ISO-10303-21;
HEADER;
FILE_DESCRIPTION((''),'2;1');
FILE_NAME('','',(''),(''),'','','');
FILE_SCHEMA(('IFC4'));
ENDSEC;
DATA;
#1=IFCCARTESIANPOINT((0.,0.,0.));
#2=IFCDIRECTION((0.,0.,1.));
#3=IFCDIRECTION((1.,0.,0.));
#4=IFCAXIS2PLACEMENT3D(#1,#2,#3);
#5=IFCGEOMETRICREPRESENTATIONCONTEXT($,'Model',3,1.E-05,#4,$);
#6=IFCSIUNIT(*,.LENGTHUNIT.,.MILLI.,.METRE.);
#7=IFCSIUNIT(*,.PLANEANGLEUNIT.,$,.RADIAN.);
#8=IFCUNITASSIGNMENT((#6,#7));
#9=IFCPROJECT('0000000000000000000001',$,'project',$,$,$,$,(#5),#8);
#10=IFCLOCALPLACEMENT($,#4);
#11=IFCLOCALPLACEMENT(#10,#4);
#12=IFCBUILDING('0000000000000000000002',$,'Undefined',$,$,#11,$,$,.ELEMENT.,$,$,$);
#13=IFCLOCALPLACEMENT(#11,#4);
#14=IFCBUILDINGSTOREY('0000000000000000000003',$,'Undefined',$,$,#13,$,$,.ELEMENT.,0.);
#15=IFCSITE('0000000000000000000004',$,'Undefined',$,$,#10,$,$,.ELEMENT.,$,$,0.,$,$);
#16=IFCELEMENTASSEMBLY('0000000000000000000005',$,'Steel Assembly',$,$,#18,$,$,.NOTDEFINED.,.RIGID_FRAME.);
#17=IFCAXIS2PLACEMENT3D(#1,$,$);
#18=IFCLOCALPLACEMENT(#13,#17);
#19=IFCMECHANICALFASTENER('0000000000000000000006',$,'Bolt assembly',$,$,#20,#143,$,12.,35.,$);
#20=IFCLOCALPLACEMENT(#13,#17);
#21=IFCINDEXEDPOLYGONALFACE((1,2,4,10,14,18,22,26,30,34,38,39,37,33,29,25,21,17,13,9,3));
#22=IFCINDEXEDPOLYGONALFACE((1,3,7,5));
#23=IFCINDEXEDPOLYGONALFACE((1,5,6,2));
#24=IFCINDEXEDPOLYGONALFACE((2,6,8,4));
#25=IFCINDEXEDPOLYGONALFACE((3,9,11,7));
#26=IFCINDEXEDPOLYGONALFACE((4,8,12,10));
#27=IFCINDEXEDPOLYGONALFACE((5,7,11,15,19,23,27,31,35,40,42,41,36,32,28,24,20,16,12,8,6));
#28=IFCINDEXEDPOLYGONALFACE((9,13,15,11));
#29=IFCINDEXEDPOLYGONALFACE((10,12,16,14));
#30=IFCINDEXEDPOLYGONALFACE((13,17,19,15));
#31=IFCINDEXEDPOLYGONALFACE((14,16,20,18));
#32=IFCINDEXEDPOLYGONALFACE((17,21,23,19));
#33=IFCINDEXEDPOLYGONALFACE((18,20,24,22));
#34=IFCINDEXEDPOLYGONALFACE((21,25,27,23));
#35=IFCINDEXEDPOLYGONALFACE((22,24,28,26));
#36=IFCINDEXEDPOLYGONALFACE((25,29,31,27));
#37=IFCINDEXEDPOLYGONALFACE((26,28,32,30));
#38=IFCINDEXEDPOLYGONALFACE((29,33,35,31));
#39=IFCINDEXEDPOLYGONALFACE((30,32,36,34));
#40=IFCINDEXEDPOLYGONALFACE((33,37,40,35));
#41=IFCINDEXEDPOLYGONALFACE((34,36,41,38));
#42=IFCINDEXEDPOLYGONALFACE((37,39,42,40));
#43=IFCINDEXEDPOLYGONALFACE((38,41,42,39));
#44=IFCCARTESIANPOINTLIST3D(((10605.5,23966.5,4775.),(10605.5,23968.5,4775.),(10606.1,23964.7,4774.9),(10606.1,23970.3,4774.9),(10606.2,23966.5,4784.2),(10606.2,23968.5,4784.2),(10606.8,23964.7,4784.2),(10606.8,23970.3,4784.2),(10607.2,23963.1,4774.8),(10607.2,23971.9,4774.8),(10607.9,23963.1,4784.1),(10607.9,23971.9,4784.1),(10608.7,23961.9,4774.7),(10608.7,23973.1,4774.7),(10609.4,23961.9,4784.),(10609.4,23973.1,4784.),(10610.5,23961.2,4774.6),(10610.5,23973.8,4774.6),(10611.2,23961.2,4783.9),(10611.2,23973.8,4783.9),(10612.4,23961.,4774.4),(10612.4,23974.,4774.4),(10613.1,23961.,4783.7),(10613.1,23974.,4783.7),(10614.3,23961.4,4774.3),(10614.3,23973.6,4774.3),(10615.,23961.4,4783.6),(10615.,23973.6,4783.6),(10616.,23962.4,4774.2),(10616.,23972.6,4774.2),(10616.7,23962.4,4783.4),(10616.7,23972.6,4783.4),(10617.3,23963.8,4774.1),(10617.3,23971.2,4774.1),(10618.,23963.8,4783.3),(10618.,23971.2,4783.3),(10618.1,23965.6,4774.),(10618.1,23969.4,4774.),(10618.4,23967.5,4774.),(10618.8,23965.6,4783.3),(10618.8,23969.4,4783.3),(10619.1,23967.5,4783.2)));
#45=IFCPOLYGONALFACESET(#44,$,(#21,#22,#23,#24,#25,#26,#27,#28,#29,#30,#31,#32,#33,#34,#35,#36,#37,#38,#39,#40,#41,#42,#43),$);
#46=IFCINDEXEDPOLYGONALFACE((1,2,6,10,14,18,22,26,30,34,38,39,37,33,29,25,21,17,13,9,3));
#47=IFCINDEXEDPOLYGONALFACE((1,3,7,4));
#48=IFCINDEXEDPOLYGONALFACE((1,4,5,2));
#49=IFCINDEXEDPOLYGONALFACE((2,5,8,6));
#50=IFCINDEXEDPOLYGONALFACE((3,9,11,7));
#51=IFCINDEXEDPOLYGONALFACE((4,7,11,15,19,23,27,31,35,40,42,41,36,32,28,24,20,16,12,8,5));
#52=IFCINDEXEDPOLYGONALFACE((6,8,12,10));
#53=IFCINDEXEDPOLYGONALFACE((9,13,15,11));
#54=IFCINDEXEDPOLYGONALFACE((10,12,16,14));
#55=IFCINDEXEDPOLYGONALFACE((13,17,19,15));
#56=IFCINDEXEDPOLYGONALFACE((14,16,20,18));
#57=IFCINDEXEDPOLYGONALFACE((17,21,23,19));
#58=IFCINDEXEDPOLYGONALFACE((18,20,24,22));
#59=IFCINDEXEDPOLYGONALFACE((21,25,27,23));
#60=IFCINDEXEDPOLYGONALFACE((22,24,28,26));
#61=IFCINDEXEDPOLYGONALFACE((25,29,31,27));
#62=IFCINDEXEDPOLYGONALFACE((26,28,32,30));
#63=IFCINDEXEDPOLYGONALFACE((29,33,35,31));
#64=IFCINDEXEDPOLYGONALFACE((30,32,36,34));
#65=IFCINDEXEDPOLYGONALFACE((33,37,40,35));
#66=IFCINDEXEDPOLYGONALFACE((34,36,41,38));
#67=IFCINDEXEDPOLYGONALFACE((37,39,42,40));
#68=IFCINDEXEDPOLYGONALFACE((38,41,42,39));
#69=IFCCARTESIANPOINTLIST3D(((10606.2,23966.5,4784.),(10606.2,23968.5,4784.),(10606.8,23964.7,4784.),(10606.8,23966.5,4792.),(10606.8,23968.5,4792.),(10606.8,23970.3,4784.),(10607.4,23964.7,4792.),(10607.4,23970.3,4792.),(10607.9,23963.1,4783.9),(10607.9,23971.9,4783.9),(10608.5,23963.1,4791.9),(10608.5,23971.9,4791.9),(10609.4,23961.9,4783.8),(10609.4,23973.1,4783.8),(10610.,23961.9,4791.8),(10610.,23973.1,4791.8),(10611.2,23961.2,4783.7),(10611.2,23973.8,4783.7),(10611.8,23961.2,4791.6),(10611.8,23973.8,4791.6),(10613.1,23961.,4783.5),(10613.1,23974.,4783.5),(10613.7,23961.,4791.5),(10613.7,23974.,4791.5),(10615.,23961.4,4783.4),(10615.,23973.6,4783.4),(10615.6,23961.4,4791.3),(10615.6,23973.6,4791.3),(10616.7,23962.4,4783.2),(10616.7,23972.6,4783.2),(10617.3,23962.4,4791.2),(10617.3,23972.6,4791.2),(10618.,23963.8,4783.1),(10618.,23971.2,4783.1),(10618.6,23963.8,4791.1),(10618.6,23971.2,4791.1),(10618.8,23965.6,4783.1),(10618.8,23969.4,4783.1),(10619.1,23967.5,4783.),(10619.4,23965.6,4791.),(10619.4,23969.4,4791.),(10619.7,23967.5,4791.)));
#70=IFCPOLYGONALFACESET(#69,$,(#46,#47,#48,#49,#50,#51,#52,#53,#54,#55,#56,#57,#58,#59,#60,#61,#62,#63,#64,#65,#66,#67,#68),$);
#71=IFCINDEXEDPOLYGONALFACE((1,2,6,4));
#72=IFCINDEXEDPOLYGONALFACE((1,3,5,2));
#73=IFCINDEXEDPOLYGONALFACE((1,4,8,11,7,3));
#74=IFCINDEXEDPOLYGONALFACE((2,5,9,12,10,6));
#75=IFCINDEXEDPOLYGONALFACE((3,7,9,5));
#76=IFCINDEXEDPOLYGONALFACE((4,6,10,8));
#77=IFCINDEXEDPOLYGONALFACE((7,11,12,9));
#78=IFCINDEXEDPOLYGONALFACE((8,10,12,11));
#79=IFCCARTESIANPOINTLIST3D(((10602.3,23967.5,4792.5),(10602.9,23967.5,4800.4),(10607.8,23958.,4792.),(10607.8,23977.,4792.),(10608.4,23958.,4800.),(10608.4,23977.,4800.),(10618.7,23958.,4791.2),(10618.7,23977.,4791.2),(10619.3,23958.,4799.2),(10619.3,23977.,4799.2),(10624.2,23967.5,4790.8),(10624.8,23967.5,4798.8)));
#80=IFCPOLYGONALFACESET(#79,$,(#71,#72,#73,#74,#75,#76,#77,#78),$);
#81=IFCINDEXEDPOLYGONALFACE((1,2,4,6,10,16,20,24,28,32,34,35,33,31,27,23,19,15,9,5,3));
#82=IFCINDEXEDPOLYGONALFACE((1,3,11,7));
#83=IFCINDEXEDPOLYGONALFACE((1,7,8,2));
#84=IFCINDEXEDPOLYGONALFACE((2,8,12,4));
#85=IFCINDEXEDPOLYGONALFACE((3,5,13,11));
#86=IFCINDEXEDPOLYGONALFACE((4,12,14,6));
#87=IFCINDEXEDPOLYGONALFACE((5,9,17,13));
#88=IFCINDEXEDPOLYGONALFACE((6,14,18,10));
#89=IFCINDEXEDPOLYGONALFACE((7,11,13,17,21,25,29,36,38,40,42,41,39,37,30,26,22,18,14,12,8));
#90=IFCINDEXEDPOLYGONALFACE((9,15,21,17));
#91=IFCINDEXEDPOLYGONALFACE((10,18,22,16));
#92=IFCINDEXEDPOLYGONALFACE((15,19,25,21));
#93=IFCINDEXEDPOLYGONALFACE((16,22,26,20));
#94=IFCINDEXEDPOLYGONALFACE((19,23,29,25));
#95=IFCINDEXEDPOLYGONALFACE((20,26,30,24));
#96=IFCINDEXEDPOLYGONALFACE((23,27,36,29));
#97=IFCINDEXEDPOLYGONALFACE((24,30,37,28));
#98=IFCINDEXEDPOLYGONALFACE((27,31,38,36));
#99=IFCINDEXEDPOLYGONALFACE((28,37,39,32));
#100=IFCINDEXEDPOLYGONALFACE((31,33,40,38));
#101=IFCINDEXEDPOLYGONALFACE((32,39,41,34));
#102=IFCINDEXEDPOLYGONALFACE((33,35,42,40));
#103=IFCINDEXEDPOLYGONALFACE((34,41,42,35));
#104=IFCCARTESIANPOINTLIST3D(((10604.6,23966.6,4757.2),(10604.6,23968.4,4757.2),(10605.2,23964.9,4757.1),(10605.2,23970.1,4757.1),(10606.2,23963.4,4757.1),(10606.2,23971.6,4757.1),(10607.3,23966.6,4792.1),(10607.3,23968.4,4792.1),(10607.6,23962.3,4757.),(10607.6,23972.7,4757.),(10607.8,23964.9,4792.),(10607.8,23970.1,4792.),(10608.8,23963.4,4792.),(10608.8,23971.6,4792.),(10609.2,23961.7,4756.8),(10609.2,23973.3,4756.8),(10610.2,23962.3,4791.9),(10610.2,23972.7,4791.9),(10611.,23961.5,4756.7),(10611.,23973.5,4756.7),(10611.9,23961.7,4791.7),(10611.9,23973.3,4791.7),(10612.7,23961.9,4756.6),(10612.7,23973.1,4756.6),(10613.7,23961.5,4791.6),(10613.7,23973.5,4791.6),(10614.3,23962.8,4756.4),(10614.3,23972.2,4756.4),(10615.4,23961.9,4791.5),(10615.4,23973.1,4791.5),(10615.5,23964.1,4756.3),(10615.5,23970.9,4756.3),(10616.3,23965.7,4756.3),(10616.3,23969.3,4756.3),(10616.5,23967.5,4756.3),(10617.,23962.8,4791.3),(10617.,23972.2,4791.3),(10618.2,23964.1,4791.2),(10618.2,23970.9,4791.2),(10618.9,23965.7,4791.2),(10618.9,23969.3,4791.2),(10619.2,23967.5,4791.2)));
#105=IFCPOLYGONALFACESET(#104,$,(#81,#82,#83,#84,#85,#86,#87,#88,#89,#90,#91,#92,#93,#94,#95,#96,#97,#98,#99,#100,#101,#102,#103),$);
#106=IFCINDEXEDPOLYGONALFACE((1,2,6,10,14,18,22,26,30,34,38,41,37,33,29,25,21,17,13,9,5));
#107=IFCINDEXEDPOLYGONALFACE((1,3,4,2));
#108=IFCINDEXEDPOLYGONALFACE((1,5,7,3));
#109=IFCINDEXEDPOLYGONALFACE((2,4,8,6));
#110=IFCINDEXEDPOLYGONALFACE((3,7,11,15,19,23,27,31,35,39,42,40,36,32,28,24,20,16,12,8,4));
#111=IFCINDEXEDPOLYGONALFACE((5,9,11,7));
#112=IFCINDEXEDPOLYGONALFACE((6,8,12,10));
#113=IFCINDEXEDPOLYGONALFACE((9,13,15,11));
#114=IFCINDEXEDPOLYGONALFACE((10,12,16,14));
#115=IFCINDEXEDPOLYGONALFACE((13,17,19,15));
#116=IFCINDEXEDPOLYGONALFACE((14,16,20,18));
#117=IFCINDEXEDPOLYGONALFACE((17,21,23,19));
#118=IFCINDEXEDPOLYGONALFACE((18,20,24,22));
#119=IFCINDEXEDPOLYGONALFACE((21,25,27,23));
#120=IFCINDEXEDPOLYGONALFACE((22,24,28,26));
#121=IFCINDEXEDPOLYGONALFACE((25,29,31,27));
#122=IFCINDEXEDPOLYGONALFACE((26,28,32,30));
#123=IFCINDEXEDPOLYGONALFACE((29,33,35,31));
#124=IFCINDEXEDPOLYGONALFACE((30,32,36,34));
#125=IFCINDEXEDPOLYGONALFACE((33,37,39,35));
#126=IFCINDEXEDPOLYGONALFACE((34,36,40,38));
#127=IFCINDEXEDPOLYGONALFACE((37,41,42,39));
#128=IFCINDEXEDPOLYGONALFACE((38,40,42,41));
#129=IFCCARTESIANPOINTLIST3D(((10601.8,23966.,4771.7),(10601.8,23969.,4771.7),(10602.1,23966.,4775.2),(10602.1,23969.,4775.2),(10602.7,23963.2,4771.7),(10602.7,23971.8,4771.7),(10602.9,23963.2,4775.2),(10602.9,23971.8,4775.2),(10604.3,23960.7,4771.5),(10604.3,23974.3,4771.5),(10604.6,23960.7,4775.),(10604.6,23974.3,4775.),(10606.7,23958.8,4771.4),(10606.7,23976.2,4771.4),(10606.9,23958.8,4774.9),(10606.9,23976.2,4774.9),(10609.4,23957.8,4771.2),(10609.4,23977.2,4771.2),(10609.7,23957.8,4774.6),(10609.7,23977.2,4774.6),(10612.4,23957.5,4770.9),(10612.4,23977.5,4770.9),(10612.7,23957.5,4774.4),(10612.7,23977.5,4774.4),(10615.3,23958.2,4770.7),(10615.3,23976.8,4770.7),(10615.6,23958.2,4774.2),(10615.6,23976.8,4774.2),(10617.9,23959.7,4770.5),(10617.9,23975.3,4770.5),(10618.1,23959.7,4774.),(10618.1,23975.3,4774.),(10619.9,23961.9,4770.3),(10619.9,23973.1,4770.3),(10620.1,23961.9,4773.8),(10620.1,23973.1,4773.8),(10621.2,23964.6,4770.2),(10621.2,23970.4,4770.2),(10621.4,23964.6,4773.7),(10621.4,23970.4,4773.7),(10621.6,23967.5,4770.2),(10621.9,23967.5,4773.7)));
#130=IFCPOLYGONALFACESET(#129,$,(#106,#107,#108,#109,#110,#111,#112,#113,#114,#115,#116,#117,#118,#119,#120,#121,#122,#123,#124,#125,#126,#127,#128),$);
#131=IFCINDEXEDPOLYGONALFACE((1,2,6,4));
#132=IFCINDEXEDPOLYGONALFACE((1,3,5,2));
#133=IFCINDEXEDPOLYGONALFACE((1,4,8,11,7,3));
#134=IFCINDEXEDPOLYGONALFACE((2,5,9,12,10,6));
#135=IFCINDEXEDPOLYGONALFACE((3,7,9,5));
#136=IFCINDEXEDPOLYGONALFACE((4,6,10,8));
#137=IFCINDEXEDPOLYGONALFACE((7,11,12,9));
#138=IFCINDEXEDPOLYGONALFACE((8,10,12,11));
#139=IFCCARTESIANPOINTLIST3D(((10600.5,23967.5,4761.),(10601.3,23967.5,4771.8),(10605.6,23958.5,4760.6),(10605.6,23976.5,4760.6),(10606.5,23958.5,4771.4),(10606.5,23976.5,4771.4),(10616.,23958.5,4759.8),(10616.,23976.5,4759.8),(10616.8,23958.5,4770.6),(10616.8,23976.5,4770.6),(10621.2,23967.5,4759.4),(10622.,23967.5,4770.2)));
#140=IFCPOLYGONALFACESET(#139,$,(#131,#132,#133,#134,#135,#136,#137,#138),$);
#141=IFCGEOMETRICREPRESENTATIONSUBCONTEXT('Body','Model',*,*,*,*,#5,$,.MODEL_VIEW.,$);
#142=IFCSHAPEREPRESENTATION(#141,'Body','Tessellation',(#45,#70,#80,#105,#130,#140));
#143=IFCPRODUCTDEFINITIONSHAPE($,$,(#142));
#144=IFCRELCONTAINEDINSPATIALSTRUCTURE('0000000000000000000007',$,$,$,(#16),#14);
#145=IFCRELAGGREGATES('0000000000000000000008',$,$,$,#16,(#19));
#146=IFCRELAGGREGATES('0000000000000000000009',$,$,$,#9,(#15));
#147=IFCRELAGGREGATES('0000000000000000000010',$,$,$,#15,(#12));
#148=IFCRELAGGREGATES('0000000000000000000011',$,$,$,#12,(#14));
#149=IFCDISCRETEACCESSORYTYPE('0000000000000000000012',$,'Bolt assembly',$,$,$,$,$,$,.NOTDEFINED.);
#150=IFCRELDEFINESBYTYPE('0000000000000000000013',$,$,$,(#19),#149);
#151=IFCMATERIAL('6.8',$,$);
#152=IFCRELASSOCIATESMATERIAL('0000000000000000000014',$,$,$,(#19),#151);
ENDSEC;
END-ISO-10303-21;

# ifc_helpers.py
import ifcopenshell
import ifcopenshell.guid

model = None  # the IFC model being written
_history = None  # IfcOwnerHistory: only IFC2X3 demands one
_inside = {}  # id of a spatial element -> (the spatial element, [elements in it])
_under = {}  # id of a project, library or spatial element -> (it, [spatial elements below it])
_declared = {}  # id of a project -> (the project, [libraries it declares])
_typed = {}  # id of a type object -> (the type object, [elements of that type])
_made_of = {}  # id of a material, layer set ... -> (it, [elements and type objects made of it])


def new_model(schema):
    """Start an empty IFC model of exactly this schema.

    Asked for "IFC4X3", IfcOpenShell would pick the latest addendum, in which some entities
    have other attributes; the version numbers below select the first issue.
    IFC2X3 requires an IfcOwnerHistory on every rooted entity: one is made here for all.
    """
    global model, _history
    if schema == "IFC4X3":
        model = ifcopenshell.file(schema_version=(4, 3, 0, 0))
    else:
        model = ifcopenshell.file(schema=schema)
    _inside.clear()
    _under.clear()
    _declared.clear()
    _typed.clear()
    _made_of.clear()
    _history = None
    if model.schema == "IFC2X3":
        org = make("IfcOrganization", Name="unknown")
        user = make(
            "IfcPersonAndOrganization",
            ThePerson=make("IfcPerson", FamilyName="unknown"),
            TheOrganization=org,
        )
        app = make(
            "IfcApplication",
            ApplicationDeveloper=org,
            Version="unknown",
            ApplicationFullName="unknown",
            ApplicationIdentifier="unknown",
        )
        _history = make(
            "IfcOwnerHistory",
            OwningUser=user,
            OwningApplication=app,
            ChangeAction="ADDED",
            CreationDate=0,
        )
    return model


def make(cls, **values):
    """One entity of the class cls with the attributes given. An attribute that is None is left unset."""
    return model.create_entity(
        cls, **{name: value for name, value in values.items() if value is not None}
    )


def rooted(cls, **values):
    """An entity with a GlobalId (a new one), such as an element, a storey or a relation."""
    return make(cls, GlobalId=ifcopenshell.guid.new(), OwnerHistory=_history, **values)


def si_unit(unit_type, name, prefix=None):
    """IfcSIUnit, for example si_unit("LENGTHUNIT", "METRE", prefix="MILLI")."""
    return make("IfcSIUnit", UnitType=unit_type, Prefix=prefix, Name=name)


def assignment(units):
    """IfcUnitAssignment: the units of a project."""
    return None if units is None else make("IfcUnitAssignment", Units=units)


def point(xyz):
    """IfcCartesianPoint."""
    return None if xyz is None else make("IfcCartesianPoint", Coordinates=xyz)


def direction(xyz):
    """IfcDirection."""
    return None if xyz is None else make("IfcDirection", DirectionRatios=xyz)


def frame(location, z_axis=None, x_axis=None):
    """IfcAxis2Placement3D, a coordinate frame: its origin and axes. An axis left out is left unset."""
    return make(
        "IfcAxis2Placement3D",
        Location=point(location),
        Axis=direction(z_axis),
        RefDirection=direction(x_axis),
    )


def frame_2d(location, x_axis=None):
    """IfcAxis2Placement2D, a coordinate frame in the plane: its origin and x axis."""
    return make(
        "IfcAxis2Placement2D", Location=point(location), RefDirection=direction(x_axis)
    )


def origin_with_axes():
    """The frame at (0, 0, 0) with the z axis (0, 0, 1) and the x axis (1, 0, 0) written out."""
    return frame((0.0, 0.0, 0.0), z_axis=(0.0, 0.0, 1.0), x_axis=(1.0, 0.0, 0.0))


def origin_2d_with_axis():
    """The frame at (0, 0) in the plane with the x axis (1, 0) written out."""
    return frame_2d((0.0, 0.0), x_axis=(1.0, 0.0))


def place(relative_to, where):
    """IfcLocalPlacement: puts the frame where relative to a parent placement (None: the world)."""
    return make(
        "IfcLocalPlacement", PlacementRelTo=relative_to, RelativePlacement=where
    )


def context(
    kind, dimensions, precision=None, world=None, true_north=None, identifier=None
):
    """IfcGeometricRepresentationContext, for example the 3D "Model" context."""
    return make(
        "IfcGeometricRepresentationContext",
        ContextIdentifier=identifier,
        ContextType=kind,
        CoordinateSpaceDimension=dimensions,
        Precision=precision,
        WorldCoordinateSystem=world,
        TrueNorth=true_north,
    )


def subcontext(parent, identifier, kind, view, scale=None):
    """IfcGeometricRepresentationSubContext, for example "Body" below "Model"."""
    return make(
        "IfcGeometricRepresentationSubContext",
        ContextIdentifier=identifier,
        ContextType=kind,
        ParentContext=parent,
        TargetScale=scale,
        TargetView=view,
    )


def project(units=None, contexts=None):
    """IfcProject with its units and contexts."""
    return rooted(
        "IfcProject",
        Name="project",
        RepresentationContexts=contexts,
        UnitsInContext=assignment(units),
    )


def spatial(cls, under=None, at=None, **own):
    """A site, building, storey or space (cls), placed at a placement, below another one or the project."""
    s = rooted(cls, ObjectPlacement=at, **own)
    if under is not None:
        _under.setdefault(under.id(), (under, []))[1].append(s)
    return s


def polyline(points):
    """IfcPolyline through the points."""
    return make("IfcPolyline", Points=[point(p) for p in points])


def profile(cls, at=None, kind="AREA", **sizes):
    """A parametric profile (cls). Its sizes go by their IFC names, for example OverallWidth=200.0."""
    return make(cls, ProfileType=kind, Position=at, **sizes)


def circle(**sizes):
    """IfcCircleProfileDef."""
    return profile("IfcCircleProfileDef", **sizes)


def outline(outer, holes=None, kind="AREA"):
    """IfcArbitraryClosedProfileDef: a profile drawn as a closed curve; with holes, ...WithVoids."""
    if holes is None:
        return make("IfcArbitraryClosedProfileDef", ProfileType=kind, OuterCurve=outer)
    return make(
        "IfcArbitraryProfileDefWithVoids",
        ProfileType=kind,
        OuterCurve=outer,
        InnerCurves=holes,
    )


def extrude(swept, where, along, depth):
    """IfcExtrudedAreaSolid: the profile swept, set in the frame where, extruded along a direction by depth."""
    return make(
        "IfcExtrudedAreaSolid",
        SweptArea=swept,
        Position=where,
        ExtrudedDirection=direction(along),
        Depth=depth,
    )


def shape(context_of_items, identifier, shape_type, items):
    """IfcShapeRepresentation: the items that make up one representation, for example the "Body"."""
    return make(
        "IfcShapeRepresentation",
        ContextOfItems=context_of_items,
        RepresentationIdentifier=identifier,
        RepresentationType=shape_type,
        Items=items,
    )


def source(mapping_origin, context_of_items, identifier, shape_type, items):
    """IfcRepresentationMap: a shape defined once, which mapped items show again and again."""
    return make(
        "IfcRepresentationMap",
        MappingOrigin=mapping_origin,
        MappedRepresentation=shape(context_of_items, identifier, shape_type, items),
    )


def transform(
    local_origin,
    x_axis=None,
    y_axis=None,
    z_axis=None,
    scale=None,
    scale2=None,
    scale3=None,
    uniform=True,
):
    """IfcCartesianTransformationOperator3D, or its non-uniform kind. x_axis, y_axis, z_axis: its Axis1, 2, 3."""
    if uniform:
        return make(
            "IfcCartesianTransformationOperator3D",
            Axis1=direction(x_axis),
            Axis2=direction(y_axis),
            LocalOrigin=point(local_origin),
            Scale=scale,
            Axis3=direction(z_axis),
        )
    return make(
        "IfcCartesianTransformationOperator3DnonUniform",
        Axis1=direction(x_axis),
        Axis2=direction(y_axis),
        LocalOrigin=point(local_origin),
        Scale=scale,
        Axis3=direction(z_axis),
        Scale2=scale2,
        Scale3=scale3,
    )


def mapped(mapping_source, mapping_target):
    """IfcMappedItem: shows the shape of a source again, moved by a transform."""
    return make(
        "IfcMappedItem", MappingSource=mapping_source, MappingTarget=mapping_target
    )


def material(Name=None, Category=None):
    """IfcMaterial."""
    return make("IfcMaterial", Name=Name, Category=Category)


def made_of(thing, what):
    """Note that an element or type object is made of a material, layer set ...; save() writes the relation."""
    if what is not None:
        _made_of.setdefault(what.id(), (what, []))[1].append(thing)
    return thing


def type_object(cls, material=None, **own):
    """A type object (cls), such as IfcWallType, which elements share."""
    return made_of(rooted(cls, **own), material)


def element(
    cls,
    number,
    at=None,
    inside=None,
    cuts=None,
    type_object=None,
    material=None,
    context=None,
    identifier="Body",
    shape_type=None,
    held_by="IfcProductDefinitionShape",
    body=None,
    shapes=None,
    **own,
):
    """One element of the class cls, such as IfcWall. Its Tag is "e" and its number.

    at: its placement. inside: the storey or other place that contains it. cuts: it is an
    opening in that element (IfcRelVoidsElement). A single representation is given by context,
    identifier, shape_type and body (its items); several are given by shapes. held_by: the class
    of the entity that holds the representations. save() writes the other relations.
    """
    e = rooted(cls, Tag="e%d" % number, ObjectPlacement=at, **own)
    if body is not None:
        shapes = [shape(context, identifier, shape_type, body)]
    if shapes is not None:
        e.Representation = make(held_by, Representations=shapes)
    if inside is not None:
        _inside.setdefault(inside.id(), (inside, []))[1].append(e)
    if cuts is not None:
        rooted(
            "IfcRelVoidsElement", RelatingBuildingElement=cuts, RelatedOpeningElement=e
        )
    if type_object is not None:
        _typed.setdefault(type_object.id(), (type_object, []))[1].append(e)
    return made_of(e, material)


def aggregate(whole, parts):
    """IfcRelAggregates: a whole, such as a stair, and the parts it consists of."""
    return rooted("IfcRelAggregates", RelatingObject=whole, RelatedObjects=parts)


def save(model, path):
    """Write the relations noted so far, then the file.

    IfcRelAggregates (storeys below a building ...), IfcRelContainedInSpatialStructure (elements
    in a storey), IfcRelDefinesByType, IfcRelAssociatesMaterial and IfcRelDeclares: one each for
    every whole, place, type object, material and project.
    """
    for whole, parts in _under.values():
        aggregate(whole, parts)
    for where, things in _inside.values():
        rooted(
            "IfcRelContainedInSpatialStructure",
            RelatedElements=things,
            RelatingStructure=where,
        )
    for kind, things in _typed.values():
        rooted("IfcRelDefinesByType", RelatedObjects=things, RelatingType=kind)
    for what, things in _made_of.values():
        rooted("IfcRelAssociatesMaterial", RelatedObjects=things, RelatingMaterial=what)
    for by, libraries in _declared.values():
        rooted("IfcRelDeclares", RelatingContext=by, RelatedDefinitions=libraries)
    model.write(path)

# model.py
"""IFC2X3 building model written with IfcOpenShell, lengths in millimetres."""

from ifc_helpers import new_model, si_unit, frame, origin_with_axes, origin_2d_with_axis, place, context, subcontext, project, spatial, polyline, circle, outline, extrude, source, transform, mapped, material, type_object, element, aggregate, save


model = new_model("IFC2X3")

# Units and contexts
model_context = context("Model", 3, precision=1e-05, world=origin_with_axes())
body_context = subcontext(model_context, "Body", "Model", "MODEL_VIEW")
ifc_project = project(units=[si_unit("LENGTHUNIT", "METRE", prefix="MILLI"), si_unit("PLANEANGLEUNIT", "RADIAN")], contexts=[model_context])

# Site, building, storey
site_placement = place(None, origin_with_axes())
site = spatial("IfcSite", under=ifc_project, at=site_placement, Name="Undefined", CompositionType="ELEMENT", RefElevation=0.0)
building_placement = place(site_placement, origin_with_axes())
building = spatial("IfcBuilding", under=site, at=building_placement, Name="Undefined", CompositionType="ELEMENT")
storey_placement = place(building_placement, origin_with_axes())
storey = spatial("IfcBuildingStorey", under=building, at=storey_placement, Name="Undefined", CompositionType="ELEMENT", Elevation=0.0)

# Shared definitions
ifc_material_1 = material(Name="6.8")
discrete_accessory_type_1 = type_object("IfcDiscreteAccessoryType", Name="Bolt assembly")

# Element assembly, mechanical fastener
shared_shape_1 = source(origin_with_axes(), body_context, "Body", "SweptSolid", [
    extrude(circle(Radius=6.5, at=origin_2d_with_axis()), frame((0.0, -0.1, 0.0), z_axis=(0.0, 1.0, 0.0), x_axis=(1.0, 0.0, 0.0)), (0.0, 0.0, 1.0), 9.3),
    extrude(circle(Radius=6.5, at=origin_2d_with_axis()), frame((0.0, -7.9, 0.0), z_axis=(0.0, 1.0, 0.0), x_axis=(1.0, 0.0, 0.0)), (0.0, 0.0, 1.0), 8.0),
    extrude(outline(polyline([(11.0, 0.0), (5.5, 9.5), (-5.5, 9.5), (-11.0, 0.0), (-5.5, -9.5), (5.5, -9.5), (11.0, 0.0)])), frame((0.0, -16.0, 0.0), z_axis=(0.0, 1.0, 0.0), x_axis=(1.0, 0.0, 0.0)), (0.0, 0.0, 1.0), 8.0),
    extrude(circle(Radius=6.0, at=origin_2d_with_axis()), frame((0.0, -8.0, 0.0), z_axis=(0.0, 1.0, 0.0), x_axis=(1.0, 0.0, 0.0)), (0.0, 0.0, 1.0), 35.0),
    extrude(circle(Radius=10.0, at=origin_2d_with_axis()), frame((0.0, 9.2, 0.0), z_axis=(0.0, 1.0, 0.0), x_axis=(1.0, 0.0, 0.0)), (0.0, 0.0, 1.0), 3.5),
    extrude(outline(polyline([(10.4, 0.0), (5.2, 9.0), (-5.2, 9.0), (-10.4, 0.0), (-5.2, -9.0), (5.2, -9.0), (10.4, 0.0)])), frame((0.0, 12.7, 0.0), z_axis=(0.0, 1.0, 0.0), x_axis=(1.0, 0.0, 0.0)), (0.0, 0.0, 1.0), 10.8),
])
assembly_1_placement = place(storey_placement, origin_with_axes())
assembly_1 = element("IfcElementAssembly", 1, at=assembly_1_placement, inside=storey, Name="Steel Assembly", AssemblyPlace="NOTDEFINED", PredefinedType="RIGID_FRAME")
mechanical_fastener_1_placement = place(assembly_1_placement, frame((10612.6, 23967.5, 4783.6), z_axis=(0.0, 1.0, 0.0), x_axis=(0.997054, 0.0, -0.076696)))
mechanical_fastener_1 = element("IfcMechanicalFastener", 2, at=mechanical_fastener_1_placement, type_object=discrete_accessory_type_1, material=ifc_material_1, Name="Bolt assembly", NominalDiameter=12.0, NominalLength=35.0, context=body_context, shape_type="MappedRepresentation", body=[
    mapped(shared_shape_1, transform((0.0, 0.0, 0.0))),
])
aggregate(assembly_1, [mechanical_fastener_1])

save(model, "model.ifc")
